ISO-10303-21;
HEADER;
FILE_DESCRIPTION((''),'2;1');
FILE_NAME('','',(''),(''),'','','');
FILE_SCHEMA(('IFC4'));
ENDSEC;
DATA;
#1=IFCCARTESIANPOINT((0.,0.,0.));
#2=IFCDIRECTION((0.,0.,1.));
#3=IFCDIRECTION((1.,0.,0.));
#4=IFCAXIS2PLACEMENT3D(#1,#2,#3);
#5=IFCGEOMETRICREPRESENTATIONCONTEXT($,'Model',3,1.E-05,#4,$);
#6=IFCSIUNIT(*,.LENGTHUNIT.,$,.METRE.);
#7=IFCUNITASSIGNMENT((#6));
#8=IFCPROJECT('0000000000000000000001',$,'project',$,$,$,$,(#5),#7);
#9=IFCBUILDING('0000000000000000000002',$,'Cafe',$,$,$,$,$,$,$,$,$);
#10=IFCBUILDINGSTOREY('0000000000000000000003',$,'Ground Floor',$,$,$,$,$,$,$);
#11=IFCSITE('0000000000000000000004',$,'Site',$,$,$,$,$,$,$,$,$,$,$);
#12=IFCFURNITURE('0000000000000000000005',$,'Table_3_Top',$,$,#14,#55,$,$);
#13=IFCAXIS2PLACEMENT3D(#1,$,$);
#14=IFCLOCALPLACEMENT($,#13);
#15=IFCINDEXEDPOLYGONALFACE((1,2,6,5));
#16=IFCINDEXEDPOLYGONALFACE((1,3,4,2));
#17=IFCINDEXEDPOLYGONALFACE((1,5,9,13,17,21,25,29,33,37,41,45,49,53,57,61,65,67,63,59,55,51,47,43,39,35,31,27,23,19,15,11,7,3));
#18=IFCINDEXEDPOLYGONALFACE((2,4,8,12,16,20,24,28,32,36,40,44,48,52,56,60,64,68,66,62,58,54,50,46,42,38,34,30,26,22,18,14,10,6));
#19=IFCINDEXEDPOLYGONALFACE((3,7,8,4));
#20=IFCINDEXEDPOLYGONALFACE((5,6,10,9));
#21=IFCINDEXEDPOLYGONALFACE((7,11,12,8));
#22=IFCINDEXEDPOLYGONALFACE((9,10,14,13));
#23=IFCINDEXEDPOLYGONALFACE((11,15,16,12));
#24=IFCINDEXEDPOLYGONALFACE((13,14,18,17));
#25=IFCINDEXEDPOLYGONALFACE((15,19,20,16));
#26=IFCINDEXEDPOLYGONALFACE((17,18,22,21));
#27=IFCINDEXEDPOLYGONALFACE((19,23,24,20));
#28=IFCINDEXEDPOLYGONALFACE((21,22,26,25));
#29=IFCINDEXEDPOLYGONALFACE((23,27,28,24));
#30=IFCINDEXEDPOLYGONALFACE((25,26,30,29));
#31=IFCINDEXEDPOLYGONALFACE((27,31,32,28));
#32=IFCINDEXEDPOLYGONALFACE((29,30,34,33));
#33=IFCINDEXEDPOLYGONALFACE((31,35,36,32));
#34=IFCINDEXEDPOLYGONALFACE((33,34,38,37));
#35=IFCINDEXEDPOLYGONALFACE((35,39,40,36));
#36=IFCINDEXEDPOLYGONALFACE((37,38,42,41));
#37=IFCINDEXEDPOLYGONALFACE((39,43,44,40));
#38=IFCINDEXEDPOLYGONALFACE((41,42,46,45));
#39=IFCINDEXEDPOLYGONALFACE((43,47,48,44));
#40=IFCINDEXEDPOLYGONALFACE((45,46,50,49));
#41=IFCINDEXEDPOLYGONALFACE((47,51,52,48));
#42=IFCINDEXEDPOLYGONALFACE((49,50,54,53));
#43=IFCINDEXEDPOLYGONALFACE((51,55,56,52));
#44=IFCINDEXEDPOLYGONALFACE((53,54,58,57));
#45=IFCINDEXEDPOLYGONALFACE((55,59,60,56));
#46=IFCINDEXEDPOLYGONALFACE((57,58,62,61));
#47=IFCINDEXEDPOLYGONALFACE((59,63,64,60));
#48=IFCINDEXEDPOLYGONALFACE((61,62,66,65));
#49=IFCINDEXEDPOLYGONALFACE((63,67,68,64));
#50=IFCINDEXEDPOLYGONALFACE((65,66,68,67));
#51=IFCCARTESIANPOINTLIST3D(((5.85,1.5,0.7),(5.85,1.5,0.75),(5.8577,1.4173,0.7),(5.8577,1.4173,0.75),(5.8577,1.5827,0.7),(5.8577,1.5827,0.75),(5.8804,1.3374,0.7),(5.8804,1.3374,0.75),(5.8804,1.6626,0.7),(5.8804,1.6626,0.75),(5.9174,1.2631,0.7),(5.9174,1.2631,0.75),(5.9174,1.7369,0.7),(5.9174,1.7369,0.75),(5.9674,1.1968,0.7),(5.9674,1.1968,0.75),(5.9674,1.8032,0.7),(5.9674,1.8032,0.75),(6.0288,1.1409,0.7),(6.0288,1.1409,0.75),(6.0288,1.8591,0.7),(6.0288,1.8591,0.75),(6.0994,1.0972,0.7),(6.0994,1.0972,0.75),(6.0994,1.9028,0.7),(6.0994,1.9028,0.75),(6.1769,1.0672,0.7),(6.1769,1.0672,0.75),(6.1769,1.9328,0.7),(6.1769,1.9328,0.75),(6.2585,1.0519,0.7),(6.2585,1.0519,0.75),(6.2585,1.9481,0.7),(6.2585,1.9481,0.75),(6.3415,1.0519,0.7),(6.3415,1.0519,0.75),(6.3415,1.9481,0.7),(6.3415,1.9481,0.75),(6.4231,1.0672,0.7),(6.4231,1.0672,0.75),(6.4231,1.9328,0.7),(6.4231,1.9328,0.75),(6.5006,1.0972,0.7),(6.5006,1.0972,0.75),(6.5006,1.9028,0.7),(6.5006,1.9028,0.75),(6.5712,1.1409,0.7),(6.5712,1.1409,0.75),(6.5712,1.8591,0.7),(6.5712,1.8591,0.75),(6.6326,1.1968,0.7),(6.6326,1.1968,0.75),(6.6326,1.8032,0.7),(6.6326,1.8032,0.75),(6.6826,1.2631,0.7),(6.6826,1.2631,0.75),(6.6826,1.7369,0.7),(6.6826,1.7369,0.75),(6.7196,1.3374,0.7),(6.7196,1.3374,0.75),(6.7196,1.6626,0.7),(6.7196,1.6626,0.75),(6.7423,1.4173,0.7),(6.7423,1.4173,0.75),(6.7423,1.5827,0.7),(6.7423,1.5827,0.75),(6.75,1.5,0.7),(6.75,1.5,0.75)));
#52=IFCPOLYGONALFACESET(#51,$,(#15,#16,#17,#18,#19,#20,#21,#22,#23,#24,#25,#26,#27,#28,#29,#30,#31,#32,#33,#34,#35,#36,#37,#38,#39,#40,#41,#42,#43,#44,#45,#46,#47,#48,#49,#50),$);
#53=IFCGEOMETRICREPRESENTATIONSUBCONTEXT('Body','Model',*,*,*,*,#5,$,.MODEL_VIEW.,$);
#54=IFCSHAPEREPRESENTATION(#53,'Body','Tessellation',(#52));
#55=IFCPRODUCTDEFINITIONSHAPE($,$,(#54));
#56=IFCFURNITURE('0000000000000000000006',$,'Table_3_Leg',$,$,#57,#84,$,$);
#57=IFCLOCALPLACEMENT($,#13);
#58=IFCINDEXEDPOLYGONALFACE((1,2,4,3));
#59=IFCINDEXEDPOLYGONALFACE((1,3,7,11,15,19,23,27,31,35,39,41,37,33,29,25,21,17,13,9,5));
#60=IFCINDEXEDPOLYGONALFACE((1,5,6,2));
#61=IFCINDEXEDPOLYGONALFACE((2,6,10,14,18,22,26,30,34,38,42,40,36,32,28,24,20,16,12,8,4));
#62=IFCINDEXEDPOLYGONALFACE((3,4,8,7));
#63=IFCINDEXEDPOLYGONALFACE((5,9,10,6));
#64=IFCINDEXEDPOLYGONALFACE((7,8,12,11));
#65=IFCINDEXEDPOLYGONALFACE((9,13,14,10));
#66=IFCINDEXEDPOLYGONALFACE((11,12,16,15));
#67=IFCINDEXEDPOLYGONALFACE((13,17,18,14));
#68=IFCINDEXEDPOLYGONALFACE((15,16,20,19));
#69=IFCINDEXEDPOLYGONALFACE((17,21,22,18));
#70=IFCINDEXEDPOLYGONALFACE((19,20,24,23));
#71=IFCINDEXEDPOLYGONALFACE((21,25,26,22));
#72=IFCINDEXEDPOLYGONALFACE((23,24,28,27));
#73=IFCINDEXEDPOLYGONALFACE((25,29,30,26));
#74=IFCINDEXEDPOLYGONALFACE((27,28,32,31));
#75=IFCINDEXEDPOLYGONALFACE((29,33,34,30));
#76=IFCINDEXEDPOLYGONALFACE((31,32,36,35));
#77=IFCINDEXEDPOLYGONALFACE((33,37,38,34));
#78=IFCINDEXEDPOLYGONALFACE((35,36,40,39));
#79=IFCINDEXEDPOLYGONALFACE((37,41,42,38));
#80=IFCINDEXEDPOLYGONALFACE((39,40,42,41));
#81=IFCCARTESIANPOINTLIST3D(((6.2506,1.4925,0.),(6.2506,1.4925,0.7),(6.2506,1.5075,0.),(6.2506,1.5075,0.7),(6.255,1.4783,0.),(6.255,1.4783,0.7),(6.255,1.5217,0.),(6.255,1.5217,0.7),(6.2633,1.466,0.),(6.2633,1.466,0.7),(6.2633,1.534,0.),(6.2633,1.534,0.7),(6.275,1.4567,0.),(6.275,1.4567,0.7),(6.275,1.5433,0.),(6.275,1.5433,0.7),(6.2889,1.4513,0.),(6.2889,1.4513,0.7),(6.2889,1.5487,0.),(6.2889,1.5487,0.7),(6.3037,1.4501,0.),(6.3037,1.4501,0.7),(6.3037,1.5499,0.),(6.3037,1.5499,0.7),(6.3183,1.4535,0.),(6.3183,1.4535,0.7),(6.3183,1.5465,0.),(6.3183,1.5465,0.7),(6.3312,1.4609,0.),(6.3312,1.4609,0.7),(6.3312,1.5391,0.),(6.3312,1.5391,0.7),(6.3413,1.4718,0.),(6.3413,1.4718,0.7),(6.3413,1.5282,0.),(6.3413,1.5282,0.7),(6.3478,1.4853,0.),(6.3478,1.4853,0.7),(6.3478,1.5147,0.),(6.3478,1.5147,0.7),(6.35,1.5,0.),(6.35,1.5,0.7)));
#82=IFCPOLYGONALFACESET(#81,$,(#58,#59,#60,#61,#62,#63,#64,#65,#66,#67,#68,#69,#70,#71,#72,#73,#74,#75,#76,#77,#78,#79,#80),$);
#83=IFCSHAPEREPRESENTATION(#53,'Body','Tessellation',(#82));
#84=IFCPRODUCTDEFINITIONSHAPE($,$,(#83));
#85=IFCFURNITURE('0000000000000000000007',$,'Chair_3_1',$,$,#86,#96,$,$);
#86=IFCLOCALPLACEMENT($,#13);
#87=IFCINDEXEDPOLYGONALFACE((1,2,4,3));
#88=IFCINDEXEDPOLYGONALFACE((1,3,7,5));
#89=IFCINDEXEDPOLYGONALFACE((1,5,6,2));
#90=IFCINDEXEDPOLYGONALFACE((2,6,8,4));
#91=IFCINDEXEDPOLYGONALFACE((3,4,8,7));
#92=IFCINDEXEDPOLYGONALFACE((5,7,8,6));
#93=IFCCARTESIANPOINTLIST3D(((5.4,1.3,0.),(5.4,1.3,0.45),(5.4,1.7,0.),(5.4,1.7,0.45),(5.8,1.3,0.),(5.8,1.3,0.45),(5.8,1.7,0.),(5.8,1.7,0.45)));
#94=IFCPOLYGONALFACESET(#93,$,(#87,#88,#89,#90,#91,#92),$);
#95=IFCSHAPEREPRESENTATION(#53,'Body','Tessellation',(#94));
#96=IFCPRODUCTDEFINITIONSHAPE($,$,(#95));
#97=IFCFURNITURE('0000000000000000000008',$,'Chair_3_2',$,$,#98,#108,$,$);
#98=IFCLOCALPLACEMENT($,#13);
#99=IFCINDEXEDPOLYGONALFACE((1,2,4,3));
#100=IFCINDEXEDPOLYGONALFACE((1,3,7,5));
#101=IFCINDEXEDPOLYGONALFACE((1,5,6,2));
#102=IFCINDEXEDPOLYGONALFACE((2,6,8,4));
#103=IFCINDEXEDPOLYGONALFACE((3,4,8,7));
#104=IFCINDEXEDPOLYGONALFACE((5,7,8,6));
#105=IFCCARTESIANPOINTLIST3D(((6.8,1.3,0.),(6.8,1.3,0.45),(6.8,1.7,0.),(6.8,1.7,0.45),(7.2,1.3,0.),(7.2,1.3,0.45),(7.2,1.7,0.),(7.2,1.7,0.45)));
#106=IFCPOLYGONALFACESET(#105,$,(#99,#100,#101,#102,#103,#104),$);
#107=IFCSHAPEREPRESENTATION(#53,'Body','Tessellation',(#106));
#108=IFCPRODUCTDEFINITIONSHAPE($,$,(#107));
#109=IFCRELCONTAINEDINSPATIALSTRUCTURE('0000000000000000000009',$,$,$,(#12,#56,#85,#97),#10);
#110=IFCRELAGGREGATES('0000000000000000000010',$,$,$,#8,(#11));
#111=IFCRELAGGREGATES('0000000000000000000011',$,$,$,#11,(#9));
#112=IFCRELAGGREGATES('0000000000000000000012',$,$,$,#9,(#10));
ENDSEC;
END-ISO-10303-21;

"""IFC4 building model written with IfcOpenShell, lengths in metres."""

from ifc_helpers import new_model, si_unit, frame, origin, origin_with_axes, origin_2d, place, context, subcontext, project, spatial, rectangle, circle, extrude, element, save


model = new_model("IFC4")

# Units and contexts
model_context = context("Model", 3, precision=1e-05, world=origin_with_axes())
body_context = subcontext(model_context, "Body", "Model", "MODEL_VIEW")
ifc_project = project(units=[si_unit("LENGTHUNIT", "METRE")], contexts=[model_context])

# Site, building, storey
site = spatial("IfcSite", under=ifc_project, Name="Site")
building = spatial("IfcBuilding", under=site, Name="Cafe")
storey = spatial("IfcBuildingStorey", under=building, Name="Ground Floor")

# Furniture
furniture_1_placement = place(None, frame((6.3, 1.5, 0.7), z_axis=(0.0, 0.0, 1.0), x_axis=(1.0, 0.0, 0.0)))
element("IfcFurniture", 1, at=furniture_1_placement, inside=storey, Name="Table_3_Top", context=body_context, shape_type="SweptSolid", body=[
    extrude(circle(Radius=0.45, at=origin_2d()), origin(), (0.0, 0.0, 1.0), 0.05),
])
furniture_2_placement = place(None, frame((6.3, 1.5, 0.0), z_axis=(0.0, 0.0, 1.0), x_axis=(1.0, 0.0, 0.0)))
element("IfcFurniture", 2, at=furniture_2_placement, inside=storey, Name="Table_3_Leg", context=body_context, shape_type="SweptSolid", body=[
    extrude(circle(Radius=0.05, at=origin_2d()), origin(), (0.0, 0.0, 1.0), 0.7),
])
for number, where, z_axis, x_axis, name in (
    (3, (5.6, 1.5, 0.0), (0.0, 0.0, 1.0), (1.0, 0.0, 0.0), "Chair_3_1"),
    (4, (7.0, 1.5, 0.0), (0.0, 0.0, 1.0), (1.0, 0.0, 0.0), "Chair_3_2"),
):
    element("IfcFurniture", number, at=place(None, frame(where, z_axis=z_axis, x_axis=x_axis)), inside=storey, Name=name, context=body_context, shape_type="SweptSolid", body=[
        extrude(rectangle(XDim=0.4, YDim=0.4, at=origin_2d()), origin(), (0.0, 0.0, 1.0), 0.45),
    ])

save(model, "model.ifc")
